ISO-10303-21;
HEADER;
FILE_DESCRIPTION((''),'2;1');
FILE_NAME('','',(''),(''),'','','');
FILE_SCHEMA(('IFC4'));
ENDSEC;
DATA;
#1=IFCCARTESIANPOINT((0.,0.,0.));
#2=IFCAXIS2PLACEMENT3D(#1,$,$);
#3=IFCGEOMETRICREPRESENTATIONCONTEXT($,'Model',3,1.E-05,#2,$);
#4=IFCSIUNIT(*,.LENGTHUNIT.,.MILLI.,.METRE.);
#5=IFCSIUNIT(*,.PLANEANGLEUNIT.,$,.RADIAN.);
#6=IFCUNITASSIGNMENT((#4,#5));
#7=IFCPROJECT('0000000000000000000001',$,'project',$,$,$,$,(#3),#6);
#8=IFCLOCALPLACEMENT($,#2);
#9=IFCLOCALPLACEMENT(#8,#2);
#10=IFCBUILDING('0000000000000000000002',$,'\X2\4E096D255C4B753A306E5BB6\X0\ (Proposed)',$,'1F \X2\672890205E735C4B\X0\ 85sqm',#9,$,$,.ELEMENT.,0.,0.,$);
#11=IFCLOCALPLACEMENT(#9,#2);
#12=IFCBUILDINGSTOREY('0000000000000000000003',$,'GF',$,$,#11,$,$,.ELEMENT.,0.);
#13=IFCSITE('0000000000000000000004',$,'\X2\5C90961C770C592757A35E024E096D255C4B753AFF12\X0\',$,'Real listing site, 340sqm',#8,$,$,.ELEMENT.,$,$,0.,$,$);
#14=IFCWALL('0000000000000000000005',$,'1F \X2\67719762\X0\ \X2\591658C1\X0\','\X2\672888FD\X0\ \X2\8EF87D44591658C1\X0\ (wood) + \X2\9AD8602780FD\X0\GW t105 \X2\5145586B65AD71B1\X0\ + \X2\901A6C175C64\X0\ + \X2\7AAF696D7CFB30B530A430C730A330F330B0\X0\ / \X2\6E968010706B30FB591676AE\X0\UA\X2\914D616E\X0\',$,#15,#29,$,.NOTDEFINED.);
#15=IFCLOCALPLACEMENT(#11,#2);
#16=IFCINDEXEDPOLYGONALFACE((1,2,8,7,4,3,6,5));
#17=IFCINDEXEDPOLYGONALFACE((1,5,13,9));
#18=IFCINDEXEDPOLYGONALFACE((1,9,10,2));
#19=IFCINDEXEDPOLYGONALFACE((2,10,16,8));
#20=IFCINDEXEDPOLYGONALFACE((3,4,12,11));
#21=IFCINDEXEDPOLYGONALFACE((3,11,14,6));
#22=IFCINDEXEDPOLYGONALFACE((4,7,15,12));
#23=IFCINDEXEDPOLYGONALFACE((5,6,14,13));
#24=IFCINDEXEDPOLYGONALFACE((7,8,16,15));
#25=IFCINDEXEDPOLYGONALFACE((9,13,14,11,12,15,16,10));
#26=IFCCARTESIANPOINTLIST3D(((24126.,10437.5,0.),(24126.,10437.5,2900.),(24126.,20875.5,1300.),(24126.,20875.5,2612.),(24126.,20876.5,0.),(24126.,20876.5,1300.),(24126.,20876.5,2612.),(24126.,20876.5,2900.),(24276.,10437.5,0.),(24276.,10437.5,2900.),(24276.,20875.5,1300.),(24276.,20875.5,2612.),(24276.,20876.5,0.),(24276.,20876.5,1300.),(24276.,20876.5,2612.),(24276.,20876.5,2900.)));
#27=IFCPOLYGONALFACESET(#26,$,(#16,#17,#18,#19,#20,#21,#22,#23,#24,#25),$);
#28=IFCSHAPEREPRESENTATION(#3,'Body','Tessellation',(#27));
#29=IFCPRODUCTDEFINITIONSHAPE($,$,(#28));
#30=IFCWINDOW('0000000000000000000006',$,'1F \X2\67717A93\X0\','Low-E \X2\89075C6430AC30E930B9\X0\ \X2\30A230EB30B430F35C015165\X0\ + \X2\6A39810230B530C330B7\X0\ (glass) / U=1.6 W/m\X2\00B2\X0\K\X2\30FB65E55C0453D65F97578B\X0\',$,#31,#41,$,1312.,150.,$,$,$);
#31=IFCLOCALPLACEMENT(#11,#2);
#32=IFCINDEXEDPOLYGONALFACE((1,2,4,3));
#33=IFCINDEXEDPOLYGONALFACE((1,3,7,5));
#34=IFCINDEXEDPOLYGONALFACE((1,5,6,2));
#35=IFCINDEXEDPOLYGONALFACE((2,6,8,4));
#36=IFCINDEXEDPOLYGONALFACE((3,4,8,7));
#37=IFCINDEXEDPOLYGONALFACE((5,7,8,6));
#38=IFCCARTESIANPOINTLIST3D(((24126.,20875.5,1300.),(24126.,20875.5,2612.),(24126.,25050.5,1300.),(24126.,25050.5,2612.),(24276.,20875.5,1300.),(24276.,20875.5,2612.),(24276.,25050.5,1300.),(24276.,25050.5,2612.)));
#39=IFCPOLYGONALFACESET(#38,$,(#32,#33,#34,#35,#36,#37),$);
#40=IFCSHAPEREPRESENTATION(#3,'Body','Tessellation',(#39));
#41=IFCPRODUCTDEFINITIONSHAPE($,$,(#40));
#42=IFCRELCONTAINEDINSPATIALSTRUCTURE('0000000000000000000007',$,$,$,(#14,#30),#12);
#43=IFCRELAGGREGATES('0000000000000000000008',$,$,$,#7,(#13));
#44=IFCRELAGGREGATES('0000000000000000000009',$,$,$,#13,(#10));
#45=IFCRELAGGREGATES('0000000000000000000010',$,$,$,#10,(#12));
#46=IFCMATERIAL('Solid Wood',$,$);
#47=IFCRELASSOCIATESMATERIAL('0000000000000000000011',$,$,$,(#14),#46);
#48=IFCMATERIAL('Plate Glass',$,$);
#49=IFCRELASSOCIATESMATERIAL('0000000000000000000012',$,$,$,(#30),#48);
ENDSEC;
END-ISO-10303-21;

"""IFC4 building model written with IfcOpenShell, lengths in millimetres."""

from ifc_helpers import new_model, si_unit, frame, frame_2d, origin, place, context, project, spatial, rectangle, extrude, material, element, fill, save


model = new_model("IFC4")

# Units and contexts
model_context = context("Model", 3, precision=1e-05, world=origin())
ifc_project = project(units=[si_unit("LENGTHUNIT", "METRE", prefix="MILLI"), si_unit("PLANEANGLEUNIT", "RADIAN")], contexts=[model_context])

# Site, building, storey
site_placement = place(None, origin())
site = spatial("IfcSite", under=ifc_project, at=site_placement, Name="岐阜県大垣市三津屋町２", ObjectType="Real listing site, 340sqm", CompositionType="ELEMENT", RefElevation=0.0)
building_placement = place(site_placement, origin())
building = spatial("IfcBuilding", under=site, at=building_placement, Name="三津屋町の家 (Proposed)", ObjectType="1F 木造平屋 85sqm", CompositionType="ELEMENT", ElevationOfRefHeight=0.0, ElevationOfTerrain=0.0)
storey_placement = place(building_placement, origin())
storey = spatial("IfcBuildingStorey", under=building, at=storey_placement, Name="GF", CompositionType="ELEMENT", Elevation=0.0)

# Shared definitions
ifc_material_1 = material(Name="Solid Wood")

# Shared definitions
ifc_material_2 = material(Name="Plate Glass")

# Wall, opening, window
wall_1_placement = place(storey_placement, frame((12063.0, 5219.0, 0.0)))
wall_1 = element("IfcWall", 1, at=wall_1_placement, inside=storey, material=ifc_material_1, Name="1F 東面 外壁", Description="木製 軸組外壁 (wood) + 高性能GW t105 充填断熱 + 通気層 + 窯業系サイディング / 準耐火・外皮UA配慮", PredefinedType="NOTDEFINED", context=model_context, shape_type="SweptSolid", body=[
    extrude(rectangle(XDim=150.0, YDim=10439.0, at=frame_2d((75.0, 5219.0))), frame((12063.0, 5219.0, 0.0)), (0.0, 0.0, 1.0), 2900.0),
])
opening_1_placement = place(storey_placement, frame((12063.0, 10438.0, 650.0)))
opening_1 = element("IfcOpeningElement", 2, at=opening_1_placement, cuts=wall_1, PredefinedType="NOTDEFINED", context=model_context, shape_type="SweptSolid", body=[
    extrude(rectangle(XDim=150.0, YDim=4175.0, at=frame_2d((75.0, 2087.0))), frame((12063.0, 10438.0, 650.0)), (0.0, 0.0, 1.0), 1312.0),
])
window_1_placement = place(storey_placement, frame((12063.0, 10438.0, 650.0)))
window_1 = element("IfcWindow", 3, at=window_1_placement, inside=storey, material=ifc_material_2, Name="1F 東窓", Description="Low-E 複層ガラス アルゴン封入 + 樹脂サッシ (glass) / U=1.6 W/m²K・日射取得型", OverallHeight=1312.0, OverallWidth=150.0, context=model_context, shape_type="SweptSolid", body=[
    extrude(rectangle(XDim=150.0, YDim=4175.0, at=frame_2d((75.0, 2087.0))), frame((12063.0, 10438.0, 650.0)), (0.0, 0.0, 1.0), 1312.0),
])
fill(opening_1, window_1)

save(model, "model.ifc")
